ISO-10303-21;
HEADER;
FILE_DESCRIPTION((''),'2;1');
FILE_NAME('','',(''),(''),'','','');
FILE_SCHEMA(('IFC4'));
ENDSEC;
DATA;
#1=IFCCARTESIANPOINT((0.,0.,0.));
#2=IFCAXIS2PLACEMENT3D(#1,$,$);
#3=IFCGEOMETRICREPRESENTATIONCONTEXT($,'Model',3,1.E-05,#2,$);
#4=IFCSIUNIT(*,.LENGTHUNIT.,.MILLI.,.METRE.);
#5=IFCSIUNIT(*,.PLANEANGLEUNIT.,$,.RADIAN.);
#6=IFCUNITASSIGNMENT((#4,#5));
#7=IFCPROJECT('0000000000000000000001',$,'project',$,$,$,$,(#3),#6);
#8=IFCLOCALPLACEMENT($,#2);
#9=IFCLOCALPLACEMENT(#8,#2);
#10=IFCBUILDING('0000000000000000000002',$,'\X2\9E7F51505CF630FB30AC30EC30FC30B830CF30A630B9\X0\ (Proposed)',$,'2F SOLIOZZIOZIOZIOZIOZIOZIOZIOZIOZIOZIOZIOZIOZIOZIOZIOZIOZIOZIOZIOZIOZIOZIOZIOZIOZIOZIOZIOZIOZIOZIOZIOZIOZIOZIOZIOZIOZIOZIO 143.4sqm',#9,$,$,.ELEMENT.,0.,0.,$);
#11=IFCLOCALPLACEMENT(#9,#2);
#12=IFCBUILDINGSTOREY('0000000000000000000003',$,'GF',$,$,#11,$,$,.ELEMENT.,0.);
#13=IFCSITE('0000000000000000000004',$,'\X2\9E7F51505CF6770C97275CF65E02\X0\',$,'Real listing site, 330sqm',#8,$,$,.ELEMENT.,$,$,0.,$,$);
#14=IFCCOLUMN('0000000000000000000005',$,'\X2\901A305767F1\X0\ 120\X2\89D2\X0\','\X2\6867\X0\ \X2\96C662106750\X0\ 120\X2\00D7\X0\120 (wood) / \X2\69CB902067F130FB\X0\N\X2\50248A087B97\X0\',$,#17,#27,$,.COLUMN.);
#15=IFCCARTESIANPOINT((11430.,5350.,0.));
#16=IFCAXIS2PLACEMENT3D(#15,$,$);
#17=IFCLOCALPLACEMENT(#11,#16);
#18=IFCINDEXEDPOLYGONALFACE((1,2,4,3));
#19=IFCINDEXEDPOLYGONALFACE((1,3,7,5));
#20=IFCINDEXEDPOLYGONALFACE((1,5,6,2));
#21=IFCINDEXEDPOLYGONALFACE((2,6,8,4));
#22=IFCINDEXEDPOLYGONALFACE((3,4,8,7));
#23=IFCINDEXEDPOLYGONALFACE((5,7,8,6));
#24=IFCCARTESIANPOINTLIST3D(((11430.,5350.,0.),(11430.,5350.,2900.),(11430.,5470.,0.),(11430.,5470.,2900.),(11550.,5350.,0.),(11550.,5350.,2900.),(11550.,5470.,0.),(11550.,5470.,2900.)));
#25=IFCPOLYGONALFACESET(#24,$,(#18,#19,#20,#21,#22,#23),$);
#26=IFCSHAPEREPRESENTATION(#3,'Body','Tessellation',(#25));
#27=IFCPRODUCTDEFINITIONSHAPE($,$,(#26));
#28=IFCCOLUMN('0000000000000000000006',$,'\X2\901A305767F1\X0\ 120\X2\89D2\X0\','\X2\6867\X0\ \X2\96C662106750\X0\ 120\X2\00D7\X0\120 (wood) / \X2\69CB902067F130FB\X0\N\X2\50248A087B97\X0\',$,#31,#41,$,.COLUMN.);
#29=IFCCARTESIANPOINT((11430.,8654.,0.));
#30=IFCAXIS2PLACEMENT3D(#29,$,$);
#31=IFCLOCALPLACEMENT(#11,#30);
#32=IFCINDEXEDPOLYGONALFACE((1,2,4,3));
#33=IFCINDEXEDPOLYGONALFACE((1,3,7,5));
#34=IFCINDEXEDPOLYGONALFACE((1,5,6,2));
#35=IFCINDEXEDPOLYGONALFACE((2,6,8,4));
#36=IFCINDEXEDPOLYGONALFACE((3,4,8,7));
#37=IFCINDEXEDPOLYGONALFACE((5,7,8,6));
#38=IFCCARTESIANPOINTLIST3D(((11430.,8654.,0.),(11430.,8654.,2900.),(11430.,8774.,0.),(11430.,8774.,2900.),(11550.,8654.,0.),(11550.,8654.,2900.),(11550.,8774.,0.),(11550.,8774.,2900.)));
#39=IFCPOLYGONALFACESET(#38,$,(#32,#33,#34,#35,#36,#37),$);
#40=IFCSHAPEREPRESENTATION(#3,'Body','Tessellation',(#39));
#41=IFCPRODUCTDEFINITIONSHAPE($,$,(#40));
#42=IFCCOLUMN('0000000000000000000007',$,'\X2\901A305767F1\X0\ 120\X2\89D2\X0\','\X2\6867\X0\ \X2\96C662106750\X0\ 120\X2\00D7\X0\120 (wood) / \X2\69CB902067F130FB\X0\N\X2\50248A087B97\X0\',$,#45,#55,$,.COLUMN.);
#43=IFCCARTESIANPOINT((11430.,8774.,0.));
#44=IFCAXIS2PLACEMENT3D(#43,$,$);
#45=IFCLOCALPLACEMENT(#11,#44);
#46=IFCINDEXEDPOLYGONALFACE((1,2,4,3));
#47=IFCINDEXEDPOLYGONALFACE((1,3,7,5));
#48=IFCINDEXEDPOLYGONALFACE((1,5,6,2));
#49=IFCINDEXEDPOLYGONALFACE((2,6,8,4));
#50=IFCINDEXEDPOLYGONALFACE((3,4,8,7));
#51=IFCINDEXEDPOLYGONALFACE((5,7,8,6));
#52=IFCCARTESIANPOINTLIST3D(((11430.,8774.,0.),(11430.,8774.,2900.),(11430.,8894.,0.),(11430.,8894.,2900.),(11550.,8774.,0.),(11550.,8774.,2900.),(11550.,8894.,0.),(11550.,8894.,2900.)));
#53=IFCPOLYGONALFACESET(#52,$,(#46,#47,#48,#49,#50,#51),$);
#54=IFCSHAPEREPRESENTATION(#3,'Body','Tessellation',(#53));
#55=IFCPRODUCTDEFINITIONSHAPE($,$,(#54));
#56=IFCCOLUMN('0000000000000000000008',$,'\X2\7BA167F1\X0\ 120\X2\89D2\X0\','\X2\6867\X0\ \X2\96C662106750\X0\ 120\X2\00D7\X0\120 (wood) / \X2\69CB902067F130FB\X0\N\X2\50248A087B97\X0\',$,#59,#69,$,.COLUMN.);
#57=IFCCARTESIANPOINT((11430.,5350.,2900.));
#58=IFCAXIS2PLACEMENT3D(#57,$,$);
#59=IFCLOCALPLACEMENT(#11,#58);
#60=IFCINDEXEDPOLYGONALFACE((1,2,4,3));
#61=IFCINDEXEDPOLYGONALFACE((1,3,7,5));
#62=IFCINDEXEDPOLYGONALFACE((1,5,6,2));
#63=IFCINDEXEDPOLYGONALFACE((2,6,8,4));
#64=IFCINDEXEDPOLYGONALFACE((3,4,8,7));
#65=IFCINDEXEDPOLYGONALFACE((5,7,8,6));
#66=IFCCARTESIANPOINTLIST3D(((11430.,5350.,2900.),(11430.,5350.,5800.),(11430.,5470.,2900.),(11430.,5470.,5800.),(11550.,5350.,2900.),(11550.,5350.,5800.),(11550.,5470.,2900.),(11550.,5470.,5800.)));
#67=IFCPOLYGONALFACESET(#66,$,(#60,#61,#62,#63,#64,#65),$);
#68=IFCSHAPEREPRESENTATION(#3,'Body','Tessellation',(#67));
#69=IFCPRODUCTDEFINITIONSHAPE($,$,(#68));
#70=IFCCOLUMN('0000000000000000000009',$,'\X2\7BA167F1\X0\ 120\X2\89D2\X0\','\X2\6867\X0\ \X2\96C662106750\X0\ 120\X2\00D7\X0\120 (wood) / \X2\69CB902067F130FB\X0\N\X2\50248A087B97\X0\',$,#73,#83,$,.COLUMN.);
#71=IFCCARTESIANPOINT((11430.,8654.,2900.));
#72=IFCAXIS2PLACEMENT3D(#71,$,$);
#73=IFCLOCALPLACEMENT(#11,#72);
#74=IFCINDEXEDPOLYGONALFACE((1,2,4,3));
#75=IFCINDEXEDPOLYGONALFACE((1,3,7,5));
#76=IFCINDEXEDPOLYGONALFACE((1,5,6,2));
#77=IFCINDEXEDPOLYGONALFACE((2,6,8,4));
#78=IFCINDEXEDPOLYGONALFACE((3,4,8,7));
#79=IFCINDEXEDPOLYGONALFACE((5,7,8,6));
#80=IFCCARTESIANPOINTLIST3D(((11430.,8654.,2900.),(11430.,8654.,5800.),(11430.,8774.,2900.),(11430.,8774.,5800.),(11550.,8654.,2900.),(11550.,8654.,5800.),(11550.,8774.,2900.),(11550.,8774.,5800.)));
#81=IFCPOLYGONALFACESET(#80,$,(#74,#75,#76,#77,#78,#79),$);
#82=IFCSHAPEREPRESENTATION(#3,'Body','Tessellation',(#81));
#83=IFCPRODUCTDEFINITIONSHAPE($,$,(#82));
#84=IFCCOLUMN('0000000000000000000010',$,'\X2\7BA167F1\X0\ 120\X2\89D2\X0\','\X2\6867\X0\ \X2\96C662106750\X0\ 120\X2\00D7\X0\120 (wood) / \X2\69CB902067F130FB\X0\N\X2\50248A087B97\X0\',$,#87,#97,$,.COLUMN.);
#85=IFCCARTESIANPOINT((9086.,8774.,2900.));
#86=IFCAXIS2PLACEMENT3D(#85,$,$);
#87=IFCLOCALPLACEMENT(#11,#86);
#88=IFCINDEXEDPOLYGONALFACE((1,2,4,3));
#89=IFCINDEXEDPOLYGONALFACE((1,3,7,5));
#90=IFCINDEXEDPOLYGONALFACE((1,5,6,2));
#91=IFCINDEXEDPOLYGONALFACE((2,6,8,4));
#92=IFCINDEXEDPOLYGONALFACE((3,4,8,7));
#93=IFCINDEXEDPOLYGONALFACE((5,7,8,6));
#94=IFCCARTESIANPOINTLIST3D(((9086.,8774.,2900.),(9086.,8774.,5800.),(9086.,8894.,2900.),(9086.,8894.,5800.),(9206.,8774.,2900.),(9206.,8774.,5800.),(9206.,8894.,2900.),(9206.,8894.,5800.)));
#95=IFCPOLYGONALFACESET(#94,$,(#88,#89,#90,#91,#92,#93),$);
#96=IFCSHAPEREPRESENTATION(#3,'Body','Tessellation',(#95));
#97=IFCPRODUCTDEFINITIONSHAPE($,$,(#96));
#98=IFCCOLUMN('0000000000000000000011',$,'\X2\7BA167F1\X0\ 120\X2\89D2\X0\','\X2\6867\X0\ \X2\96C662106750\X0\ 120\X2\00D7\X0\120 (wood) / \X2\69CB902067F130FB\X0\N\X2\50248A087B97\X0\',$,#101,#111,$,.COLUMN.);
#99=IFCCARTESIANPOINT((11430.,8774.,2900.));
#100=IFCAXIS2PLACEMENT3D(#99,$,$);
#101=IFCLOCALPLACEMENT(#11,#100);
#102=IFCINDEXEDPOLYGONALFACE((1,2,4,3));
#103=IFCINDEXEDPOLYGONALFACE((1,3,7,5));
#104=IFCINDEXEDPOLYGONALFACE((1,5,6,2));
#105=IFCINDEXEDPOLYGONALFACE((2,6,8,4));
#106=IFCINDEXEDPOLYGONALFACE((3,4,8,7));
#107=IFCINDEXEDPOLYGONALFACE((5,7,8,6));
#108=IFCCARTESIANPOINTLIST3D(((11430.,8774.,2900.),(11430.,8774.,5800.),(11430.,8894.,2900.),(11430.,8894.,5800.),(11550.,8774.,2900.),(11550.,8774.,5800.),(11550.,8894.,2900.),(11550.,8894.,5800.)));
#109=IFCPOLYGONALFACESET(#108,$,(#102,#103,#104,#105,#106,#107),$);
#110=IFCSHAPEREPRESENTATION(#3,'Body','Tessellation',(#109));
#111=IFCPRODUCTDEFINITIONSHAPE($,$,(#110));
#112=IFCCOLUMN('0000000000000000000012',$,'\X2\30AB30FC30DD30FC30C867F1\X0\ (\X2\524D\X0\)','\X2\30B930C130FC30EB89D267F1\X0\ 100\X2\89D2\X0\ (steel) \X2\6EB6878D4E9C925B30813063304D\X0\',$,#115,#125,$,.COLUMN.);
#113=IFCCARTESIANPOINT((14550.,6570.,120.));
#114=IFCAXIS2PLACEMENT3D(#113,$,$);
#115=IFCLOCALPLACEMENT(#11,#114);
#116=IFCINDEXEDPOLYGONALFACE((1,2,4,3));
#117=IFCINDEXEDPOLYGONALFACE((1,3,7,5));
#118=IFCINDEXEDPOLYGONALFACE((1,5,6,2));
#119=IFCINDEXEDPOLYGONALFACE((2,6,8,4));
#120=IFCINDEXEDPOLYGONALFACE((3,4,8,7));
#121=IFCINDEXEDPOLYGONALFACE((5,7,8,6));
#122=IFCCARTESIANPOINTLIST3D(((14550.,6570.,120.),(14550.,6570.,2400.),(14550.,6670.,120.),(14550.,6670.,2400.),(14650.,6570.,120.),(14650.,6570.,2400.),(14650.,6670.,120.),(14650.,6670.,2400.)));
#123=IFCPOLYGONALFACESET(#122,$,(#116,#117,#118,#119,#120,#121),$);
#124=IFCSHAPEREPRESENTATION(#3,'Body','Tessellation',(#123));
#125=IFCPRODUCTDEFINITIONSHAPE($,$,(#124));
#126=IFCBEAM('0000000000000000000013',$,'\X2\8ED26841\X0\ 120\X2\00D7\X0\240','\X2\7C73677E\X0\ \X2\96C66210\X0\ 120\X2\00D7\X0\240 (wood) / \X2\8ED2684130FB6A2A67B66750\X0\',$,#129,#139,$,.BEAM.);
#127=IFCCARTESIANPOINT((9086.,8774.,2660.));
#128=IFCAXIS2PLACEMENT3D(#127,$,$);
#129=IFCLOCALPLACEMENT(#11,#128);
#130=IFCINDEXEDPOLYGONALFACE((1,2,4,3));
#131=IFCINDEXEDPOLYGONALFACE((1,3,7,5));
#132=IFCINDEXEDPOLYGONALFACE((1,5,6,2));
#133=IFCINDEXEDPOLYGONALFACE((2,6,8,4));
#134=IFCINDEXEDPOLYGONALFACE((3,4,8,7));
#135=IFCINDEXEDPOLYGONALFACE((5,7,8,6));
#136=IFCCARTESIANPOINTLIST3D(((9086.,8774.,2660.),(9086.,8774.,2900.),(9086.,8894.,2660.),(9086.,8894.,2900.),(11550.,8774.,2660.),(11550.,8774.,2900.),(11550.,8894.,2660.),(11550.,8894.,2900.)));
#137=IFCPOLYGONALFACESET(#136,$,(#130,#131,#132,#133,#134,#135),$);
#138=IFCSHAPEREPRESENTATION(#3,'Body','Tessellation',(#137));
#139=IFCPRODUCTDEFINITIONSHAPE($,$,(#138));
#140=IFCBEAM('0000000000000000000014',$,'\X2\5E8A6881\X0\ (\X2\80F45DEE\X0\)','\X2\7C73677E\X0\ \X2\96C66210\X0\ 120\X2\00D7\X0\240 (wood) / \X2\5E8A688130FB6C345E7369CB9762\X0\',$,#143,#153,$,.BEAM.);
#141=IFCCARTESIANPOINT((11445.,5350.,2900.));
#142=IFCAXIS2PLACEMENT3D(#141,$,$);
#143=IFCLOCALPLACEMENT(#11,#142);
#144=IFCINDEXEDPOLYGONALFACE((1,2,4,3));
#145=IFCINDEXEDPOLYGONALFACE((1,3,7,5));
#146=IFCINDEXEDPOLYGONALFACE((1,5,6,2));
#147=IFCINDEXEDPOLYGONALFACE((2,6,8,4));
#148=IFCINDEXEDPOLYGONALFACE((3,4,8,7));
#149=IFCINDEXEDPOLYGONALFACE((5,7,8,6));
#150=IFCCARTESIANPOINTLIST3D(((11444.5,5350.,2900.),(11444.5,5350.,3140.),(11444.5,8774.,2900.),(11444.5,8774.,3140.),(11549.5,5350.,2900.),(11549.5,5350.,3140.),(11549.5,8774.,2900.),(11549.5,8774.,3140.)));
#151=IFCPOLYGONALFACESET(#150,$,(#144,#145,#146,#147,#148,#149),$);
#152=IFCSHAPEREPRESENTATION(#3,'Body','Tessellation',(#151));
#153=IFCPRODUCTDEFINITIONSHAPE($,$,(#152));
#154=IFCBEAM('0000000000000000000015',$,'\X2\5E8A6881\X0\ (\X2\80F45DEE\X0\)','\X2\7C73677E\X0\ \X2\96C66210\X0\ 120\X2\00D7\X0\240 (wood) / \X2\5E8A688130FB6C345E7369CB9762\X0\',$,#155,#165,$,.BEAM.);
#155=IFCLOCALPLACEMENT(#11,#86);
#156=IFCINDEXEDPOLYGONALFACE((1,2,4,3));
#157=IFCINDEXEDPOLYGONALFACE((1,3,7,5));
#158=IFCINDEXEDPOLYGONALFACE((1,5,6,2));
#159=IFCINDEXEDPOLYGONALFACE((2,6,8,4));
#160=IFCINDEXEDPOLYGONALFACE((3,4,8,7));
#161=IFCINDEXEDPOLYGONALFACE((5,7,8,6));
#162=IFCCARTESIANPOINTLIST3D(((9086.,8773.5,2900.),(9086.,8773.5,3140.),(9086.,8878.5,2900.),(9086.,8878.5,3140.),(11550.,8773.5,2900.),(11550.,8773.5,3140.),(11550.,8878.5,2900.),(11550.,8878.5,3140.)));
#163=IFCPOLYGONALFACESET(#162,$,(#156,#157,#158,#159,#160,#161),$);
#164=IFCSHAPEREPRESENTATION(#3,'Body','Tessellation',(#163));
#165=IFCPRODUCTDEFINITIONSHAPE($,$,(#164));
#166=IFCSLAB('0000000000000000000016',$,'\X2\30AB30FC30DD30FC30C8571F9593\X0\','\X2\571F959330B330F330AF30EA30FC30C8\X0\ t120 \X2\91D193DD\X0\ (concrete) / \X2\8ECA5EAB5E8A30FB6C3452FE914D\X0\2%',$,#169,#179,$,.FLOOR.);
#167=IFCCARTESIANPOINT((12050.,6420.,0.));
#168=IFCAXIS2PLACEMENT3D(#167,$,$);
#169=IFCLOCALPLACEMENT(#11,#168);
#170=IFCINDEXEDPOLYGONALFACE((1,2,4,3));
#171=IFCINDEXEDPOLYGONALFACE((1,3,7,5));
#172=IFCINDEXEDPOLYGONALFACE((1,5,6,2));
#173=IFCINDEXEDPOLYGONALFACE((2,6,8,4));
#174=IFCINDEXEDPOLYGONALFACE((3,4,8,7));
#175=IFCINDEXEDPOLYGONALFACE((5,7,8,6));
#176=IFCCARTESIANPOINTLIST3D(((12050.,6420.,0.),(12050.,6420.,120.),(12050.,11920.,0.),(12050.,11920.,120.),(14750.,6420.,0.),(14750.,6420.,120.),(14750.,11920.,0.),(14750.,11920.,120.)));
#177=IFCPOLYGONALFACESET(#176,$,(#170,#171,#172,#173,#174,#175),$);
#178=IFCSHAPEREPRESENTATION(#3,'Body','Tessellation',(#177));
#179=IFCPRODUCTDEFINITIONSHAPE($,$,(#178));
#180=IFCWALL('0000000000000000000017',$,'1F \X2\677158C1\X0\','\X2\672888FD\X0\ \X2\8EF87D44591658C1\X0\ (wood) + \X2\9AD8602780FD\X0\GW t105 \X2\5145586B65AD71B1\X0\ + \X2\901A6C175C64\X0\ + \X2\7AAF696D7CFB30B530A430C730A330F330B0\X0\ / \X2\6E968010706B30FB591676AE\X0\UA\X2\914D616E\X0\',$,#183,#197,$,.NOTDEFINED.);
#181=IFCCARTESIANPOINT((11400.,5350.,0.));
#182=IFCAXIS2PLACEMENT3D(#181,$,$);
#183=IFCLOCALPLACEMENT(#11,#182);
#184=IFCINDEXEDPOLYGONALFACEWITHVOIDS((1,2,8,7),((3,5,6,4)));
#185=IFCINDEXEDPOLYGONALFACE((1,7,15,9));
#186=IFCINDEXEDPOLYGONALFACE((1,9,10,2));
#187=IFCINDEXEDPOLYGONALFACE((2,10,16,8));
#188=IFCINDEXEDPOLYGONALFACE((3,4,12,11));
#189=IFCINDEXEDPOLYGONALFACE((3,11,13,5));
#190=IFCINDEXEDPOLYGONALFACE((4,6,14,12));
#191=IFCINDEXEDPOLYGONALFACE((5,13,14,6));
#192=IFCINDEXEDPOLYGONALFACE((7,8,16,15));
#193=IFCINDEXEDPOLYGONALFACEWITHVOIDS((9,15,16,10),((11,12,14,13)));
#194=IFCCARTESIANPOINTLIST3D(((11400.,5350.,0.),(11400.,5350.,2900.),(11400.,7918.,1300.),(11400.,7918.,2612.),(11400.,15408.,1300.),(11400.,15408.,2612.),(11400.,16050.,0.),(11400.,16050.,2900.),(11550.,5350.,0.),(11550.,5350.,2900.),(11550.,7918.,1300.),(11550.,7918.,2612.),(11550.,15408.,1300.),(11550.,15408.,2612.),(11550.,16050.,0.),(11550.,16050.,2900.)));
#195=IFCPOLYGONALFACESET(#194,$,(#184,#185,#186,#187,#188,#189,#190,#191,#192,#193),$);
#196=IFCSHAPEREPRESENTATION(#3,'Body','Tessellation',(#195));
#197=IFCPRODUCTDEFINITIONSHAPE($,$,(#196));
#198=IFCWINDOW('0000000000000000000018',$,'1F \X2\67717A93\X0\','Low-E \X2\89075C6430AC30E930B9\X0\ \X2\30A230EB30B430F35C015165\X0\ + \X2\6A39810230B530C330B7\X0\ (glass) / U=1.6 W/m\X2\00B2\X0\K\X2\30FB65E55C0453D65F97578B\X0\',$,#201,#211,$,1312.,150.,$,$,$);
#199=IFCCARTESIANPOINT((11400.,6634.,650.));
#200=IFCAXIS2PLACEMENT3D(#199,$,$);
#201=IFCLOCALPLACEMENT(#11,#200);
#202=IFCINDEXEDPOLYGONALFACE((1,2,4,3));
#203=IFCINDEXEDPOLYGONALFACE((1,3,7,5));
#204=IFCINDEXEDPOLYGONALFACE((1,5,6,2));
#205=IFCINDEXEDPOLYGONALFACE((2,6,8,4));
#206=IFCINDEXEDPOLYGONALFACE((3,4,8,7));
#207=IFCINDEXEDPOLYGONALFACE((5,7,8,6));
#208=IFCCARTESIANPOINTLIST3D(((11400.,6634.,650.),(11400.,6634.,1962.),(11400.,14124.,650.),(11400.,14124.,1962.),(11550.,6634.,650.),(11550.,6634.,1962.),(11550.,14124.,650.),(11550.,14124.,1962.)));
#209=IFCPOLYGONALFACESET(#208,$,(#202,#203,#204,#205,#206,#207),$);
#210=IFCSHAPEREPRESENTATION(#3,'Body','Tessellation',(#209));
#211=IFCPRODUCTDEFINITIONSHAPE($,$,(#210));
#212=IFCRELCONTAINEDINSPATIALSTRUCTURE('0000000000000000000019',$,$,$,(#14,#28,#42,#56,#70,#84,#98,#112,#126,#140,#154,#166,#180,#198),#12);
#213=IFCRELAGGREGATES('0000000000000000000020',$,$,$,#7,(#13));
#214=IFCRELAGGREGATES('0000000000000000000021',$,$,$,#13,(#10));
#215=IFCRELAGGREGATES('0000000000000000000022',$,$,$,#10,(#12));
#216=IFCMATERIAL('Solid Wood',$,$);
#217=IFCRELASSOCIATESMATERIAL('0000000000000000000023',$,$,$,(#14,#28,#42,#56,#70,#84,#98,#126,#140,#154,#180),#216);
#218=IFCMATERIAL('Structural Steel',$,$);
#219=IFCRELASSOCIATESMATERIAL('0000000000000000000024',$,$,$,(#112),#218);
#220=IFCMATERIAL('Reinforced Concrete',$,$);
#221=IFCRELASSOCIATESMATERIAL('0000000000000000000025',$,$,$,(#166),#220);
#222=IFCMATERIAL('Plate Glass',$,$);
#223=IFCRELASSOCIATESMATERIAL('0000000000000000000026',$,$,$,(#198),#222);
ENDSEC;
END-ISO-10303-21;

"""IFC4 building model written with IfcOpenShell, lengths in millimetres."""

from ifc_helpers import new_model, si_unit, frame, frame_2d, origin, place, context, project, spatial, rectangle, extrude, material, element, fill, save


model = new_model("IFC4")

# Units and contexts
model_context = context("Model", 3, precision=1e-05, world=origin())
ifc_project = project(units=[si_unit("LENGTHUNIT", "METRE", prefix="MILLI"), si_unit("PLANEANGLEUNIT", "RADIAN")], contexts=[model_context])

# Site, building, storey
site_placement = place(None, origin())
site = spatial("IfcSite", under=ifc_project, at=site_placement, Name="鹿児島県霧島市", ObjectType="Real listing site, 330sqm", CompositionType="ELEMENT", RefElevation=0.0)
building_placement = place(site_placement, origin())
building = spatial("IfcBuilding", under=site, at=building_placement, Name="鹿児島・ガレージハウス (Proposed)", ObjectType="2F SOLIOZZIOZIOZIOZIOZIOZIOZIOZIOZIOZIOZIOZIOZIOZIOZIOZIOZIOZIOZIOZIOZIOZIOZIOZIOZIOZIOZIOZIOZIOZIOZIOZIOZIOZIOZIOZIOZIOZIO 143.4sqm", CompositionType="ELEMENT", ElevationOfRefHeight=0.0, ElevationOfTerrain=0.0)
storey_placement = place(building_placement, origin())
storey = spatial("IfcBuildingStorey", under=building, at=storey_placement, Name="GF", CompositionType="ELEMENT", Elevation=0.0)

# Columns
ifc_material_1 = material(Name="Solid Wood")
column_1_placement = place(storey_placement, frame((11430.0, 5350.0, 0.0)))
element("IfcColumn", 1, at=column_1_placement, inside=storey, material=ifc_material_1, Name="通し柱 120角", Description="桧 集成材 120×120 (wood) / 構造柱・N値計算", PredefinedType="COLUMN", context=model_context, shape_type="SweptSolid", body=[
    extrude(rectangle(XDim=120.0, YDim=120.0, at=frame_2d((60.0, 60.0))), frame((11430.0, 5350.0, 0.0)), (0.0, 0.0, 1.0), 2900.0),
])
column_2_placement = place(storey_placement, frame((11430.0, 8654.0, 0.0)))
element("IfcColumn", 2, at=column_2_placement, inside=storey, material=ifc_material_1, Name="通し柱 120角", Description="桧 集成材 120×120 (wood) / 構造柱・N値計算", PredefinedType="COLUMN", context=model_context, shape_type="SweptSolid", body=[
    extrude(rectangle(XDim=120.0, YDim=120.0, at=frame_2d((60.0, 60.0))), frame((11430.0, 8654.0, 0.0)), (0.0, 0.0, 1.0), 2900.0),
])
column_3_placement = place(storey_placement, frame((11430.0, 8774.0, 0.0)))
element("IfcColumn", 3, at=column_3_placement, inside=storey, material=ifc_material_1, Name="通し柱 120角", Description="桧 集成材 120×120 (wood) / 構造柱・N値計算", PredefinedType="COLUMN", context=model_context, shape_type="SweptSolid", body=[
    extrude(rectangle(XDim=120.0, YDim=120.0, at=frame_2d((60.0, 60.0))), frame((11430.0, 8774.0, 0.0)), (0.0, 0.0, 1.0), 2900.0),
])
column_4_placement = place(storey_placement, frame((11430.0, 5350.0, 2900.0)))
element("IfcColumn", 4, at=column_4_placement, inside=storey, material=ifc_material_1, Name="管柱 120角", Description="桧 集成材 120×120 (wood) / 構造柱・N値計算", PredefinedType="COLUMN", context=model_context, shape_type="SweptSolid", body=[
    extrude(rectangle(XDim=120.0, YDim=120.0, at=frame_2d((60.0, 60.0))), frame((11430.0, 5350.0, 2900.0)), (0.0, 0.0, 1.0), 2900.0),
])
column_5_placement = place(storey_placement, frame((11430.0, 8654.0, 2900.0)))
element("IfcColumn", 5, at=column_5_placement, inside=storey, material=ifc_material_1, Name="管柱 120角", Description="桧 集成材 120×120 (wood) / 構造柱・N値計算", PredefinedType="COLUMN", context=model_context, shape_type="SweptSolid", body=[
    extrude(rectangle(XDim=120.0, YDim=120.0, at=frame_2d((60.0, 60.0))), frame((11430.0, 8654.0, 2900.0)), (0.0, 0.0, 1.0), 2900.0),
])
column_6_placement = place(storey_placement, frame((9086.0, 8774.0, 2900.0)))
element("IfcColumn", 6, at=column_6_placement, inside=storey, material=ifc_material_1, Name="管柱 120角", Description="桧 集成材 120×120 (wood) / 構造柱・N値計算", PredefinedType="COLUMN", context=model_context, shape_type="SweptSolid", body=[
    extrude(rectangle(XDim=120.0, YDim=120.0, at=frame_2d((60.0, 60.0))), frame((9086.0, 8774.0, 2900.0)), (0.0, 0.0, 1.0), 2900.0),
])
column_7_placement = place(storey_placement, frame((11430.0, 8774.0, 2900.0)))
element("IfcColumn", 7, at=column_7_placement, inside=storey, material=ifc_material_1, Name="管柱 120角", Description="桧 集成材 120×120 (wood) / 構造柱・N値計算", PredefinedType="COLUMN", context=model_context, shape_type="SweptSolid", body=[
    extrude(rectangle(XDim=120.0, YDim=120.0, at=frame_2d((60.0, 60.0))), frame((11430.0, 8774.0, 2900.0)), (0.0, 0.0, 1.0), 2900.0),
])
ifc_material_2 = material(Name="Structural Steel")
column_8_placement = place(storey_placement, frame((14550.0, 6570.0, 120.0)))
element("IfcColumn", 8, at=column_8_placement, inside=storey, material=ifc_material_2, Name="カーポート柱 (前)", Description="スチール角柱 100角 (steel) 溶融亜鉛めっき", PredefinedType="COLUMN", context=model_context, shape_type="SweptSolid", body=[
    extrude(rectangle(XDim=100.0, YDim=100.0, at=frame_2d((50.0, 50.0))), frame((14550.0, 6570.0, 120.0)), (0.0, 0.0, 1.0), 2280.0),
])

# Beams
beam_1_placement = place(storey_placement, frame((9086.0, 8774.0, 2660.0)))
element("IfcBeam", 9, at=beam_1_placement, inside=storey, material=ifc_material_1, Name="軒桁 120×240", Description="米松 集成 120×240 (wood) / 軒桁・横架材", PredefinedType="BEAM", context=model_context, shape_type="SweptSolid", body=[
    extrude(rectangle(XDim=2464.0, YDim=120.0, at=frame_2d((1232.0, 60.0))), frame((9086.0, 8774.0, 2660.0)), (0.0, 0.0, 1.0), 240.0),
])
beam_2_placement = place(storey_placement, frame((11445.0, 5350.0, 2900.0)))
element("IfcBeam", 10, at=beam_2_placement, inside=storey, material=ifc_material_1, Name="床梁 (胴差)", Description="米松 集成 120×240 (wood) / 床梁・水平構面", PredefinedType="BEAM", context=model_context, shape_type="SweptSolid", body=[
    extrude(rectangle(XDim=105.0, YDim=3424.0, at=frame_2d((52.0, 1712.0))), frame((11445.0, 5350.0, 2900.0)), (0.0, 0.0, 1.0), 240.0),
])
beam_3_placement = place(storey_placement, frame((9086.0, 8774.0, 2900.0)))
element("IfcBeam", 11, at=beam_3_placement, inside=storey, material=ifc_material_1, Name="床梁 (胴差)", Description="米松 集成 120×240 (wood) / 床梁・水平構面", PredefinedType="BEAM", context=model_context, shape_type="SweptSolid", body=[
    extrude(rectangle(XDim=2464.0, YDim=105.0, at=frame_2d((1232.0, 52.0))), frame((9086.0, 8774.0, 2900.0)), (0.0, 0.0, 1.0), 240.0),
])

# Slab
ifc_material_3 = material(Name="Reinforced Concrete")
slab_placement = place(storey_placement, frame((12050.0, 6420.0, 0.0)))
element("IfcSlab", 12, at=slab_placement, inside=storey, material=ifc_material_3, Name="カーポート土間", Description="土間コンクリート t120 金鏝 (concrete) / 車庫床・水勾配2%", PredefinedType="FLOOR", context=model_context, shape_type="SweptSolid", body=[
    extrude(rectangle(XDim=2700.0, YDim=5500.0, at=frame_2d((1350.0, 2750.0))), frame((12050.0, 6420.0, 0.0)), (0.0, 0.0, 1.0), 120.0),
])

# Wall, opening, window
wall_1_placement = place(storey_placement, frame((11400.0, 5350.0, 0.0)))
wall_1 = element("IfcWall", 13, at=wall_1_placement, inside=storey, material=ifc_material_1, Name="1F 東壁", Description="木製 軸組外壁 (wood) + 高性能GW t105 充填断熱 + 通気層 + 窯業系サイディング / 準耐火・外皮UA配慮", PredefinedType="NOTDEFINED", context=model_context, shape_type="SweptSolid", body=[
    extrude(rectangle(XDim=150.0, YDim=10700.0, at=frame_2d((75.0, 5350.0))), frame((11400.0, 5350.0, 0.0)), (0.0, 0.0, 1.0), 2900.0),
])
opening_1_placement = place(storey_placement, frame((11400.0, 6634.0, 650.0)))
opening_1 = element("IfcOpeningElement", 14, at=opening_1_placement, cuts=wall_1, PredefinedType="NOTDEFINED", context=model_context, shape_type="SweptSolid", body=[
    extrude(rectangle(XDim=150.0, YDim=7490.0, at=frame_2d((75.0, 3745.0))), frame((11400.0, 6634.0, 650.0)), (0.0, 0.0, 1.0), 1312.0),
])
ifc_material_4 = material(Name="Plate Glass")
window_1_placement = place(storey_placement, frame((11400.0, 6634.0, 650.0)))
window_1 = element("IfcWindow", 15, at=window_1_placement, inside=storey, material=ifc_material_4, Name="1F 東窓", Description="Low-E 複層ガラス アルゴン封入 + 樹脂サッシ (glass) / U=1.6 W/m²K・日射取得型", OverallHeight=1312.0, OverallWidth=150.0, context=model_context, shape_type="SweptSolid", body=[
    extrude(rectangle(XDim=150.0, YDim=7490.0, at=frame_2d((75.0, 3745.0))), frame((11400.0, 6634.0, 650.0)), (0.0, 0.0, 1.0), 1312.0),
])
fill(opening_1, window_1)

save(model, "model.ifc")
